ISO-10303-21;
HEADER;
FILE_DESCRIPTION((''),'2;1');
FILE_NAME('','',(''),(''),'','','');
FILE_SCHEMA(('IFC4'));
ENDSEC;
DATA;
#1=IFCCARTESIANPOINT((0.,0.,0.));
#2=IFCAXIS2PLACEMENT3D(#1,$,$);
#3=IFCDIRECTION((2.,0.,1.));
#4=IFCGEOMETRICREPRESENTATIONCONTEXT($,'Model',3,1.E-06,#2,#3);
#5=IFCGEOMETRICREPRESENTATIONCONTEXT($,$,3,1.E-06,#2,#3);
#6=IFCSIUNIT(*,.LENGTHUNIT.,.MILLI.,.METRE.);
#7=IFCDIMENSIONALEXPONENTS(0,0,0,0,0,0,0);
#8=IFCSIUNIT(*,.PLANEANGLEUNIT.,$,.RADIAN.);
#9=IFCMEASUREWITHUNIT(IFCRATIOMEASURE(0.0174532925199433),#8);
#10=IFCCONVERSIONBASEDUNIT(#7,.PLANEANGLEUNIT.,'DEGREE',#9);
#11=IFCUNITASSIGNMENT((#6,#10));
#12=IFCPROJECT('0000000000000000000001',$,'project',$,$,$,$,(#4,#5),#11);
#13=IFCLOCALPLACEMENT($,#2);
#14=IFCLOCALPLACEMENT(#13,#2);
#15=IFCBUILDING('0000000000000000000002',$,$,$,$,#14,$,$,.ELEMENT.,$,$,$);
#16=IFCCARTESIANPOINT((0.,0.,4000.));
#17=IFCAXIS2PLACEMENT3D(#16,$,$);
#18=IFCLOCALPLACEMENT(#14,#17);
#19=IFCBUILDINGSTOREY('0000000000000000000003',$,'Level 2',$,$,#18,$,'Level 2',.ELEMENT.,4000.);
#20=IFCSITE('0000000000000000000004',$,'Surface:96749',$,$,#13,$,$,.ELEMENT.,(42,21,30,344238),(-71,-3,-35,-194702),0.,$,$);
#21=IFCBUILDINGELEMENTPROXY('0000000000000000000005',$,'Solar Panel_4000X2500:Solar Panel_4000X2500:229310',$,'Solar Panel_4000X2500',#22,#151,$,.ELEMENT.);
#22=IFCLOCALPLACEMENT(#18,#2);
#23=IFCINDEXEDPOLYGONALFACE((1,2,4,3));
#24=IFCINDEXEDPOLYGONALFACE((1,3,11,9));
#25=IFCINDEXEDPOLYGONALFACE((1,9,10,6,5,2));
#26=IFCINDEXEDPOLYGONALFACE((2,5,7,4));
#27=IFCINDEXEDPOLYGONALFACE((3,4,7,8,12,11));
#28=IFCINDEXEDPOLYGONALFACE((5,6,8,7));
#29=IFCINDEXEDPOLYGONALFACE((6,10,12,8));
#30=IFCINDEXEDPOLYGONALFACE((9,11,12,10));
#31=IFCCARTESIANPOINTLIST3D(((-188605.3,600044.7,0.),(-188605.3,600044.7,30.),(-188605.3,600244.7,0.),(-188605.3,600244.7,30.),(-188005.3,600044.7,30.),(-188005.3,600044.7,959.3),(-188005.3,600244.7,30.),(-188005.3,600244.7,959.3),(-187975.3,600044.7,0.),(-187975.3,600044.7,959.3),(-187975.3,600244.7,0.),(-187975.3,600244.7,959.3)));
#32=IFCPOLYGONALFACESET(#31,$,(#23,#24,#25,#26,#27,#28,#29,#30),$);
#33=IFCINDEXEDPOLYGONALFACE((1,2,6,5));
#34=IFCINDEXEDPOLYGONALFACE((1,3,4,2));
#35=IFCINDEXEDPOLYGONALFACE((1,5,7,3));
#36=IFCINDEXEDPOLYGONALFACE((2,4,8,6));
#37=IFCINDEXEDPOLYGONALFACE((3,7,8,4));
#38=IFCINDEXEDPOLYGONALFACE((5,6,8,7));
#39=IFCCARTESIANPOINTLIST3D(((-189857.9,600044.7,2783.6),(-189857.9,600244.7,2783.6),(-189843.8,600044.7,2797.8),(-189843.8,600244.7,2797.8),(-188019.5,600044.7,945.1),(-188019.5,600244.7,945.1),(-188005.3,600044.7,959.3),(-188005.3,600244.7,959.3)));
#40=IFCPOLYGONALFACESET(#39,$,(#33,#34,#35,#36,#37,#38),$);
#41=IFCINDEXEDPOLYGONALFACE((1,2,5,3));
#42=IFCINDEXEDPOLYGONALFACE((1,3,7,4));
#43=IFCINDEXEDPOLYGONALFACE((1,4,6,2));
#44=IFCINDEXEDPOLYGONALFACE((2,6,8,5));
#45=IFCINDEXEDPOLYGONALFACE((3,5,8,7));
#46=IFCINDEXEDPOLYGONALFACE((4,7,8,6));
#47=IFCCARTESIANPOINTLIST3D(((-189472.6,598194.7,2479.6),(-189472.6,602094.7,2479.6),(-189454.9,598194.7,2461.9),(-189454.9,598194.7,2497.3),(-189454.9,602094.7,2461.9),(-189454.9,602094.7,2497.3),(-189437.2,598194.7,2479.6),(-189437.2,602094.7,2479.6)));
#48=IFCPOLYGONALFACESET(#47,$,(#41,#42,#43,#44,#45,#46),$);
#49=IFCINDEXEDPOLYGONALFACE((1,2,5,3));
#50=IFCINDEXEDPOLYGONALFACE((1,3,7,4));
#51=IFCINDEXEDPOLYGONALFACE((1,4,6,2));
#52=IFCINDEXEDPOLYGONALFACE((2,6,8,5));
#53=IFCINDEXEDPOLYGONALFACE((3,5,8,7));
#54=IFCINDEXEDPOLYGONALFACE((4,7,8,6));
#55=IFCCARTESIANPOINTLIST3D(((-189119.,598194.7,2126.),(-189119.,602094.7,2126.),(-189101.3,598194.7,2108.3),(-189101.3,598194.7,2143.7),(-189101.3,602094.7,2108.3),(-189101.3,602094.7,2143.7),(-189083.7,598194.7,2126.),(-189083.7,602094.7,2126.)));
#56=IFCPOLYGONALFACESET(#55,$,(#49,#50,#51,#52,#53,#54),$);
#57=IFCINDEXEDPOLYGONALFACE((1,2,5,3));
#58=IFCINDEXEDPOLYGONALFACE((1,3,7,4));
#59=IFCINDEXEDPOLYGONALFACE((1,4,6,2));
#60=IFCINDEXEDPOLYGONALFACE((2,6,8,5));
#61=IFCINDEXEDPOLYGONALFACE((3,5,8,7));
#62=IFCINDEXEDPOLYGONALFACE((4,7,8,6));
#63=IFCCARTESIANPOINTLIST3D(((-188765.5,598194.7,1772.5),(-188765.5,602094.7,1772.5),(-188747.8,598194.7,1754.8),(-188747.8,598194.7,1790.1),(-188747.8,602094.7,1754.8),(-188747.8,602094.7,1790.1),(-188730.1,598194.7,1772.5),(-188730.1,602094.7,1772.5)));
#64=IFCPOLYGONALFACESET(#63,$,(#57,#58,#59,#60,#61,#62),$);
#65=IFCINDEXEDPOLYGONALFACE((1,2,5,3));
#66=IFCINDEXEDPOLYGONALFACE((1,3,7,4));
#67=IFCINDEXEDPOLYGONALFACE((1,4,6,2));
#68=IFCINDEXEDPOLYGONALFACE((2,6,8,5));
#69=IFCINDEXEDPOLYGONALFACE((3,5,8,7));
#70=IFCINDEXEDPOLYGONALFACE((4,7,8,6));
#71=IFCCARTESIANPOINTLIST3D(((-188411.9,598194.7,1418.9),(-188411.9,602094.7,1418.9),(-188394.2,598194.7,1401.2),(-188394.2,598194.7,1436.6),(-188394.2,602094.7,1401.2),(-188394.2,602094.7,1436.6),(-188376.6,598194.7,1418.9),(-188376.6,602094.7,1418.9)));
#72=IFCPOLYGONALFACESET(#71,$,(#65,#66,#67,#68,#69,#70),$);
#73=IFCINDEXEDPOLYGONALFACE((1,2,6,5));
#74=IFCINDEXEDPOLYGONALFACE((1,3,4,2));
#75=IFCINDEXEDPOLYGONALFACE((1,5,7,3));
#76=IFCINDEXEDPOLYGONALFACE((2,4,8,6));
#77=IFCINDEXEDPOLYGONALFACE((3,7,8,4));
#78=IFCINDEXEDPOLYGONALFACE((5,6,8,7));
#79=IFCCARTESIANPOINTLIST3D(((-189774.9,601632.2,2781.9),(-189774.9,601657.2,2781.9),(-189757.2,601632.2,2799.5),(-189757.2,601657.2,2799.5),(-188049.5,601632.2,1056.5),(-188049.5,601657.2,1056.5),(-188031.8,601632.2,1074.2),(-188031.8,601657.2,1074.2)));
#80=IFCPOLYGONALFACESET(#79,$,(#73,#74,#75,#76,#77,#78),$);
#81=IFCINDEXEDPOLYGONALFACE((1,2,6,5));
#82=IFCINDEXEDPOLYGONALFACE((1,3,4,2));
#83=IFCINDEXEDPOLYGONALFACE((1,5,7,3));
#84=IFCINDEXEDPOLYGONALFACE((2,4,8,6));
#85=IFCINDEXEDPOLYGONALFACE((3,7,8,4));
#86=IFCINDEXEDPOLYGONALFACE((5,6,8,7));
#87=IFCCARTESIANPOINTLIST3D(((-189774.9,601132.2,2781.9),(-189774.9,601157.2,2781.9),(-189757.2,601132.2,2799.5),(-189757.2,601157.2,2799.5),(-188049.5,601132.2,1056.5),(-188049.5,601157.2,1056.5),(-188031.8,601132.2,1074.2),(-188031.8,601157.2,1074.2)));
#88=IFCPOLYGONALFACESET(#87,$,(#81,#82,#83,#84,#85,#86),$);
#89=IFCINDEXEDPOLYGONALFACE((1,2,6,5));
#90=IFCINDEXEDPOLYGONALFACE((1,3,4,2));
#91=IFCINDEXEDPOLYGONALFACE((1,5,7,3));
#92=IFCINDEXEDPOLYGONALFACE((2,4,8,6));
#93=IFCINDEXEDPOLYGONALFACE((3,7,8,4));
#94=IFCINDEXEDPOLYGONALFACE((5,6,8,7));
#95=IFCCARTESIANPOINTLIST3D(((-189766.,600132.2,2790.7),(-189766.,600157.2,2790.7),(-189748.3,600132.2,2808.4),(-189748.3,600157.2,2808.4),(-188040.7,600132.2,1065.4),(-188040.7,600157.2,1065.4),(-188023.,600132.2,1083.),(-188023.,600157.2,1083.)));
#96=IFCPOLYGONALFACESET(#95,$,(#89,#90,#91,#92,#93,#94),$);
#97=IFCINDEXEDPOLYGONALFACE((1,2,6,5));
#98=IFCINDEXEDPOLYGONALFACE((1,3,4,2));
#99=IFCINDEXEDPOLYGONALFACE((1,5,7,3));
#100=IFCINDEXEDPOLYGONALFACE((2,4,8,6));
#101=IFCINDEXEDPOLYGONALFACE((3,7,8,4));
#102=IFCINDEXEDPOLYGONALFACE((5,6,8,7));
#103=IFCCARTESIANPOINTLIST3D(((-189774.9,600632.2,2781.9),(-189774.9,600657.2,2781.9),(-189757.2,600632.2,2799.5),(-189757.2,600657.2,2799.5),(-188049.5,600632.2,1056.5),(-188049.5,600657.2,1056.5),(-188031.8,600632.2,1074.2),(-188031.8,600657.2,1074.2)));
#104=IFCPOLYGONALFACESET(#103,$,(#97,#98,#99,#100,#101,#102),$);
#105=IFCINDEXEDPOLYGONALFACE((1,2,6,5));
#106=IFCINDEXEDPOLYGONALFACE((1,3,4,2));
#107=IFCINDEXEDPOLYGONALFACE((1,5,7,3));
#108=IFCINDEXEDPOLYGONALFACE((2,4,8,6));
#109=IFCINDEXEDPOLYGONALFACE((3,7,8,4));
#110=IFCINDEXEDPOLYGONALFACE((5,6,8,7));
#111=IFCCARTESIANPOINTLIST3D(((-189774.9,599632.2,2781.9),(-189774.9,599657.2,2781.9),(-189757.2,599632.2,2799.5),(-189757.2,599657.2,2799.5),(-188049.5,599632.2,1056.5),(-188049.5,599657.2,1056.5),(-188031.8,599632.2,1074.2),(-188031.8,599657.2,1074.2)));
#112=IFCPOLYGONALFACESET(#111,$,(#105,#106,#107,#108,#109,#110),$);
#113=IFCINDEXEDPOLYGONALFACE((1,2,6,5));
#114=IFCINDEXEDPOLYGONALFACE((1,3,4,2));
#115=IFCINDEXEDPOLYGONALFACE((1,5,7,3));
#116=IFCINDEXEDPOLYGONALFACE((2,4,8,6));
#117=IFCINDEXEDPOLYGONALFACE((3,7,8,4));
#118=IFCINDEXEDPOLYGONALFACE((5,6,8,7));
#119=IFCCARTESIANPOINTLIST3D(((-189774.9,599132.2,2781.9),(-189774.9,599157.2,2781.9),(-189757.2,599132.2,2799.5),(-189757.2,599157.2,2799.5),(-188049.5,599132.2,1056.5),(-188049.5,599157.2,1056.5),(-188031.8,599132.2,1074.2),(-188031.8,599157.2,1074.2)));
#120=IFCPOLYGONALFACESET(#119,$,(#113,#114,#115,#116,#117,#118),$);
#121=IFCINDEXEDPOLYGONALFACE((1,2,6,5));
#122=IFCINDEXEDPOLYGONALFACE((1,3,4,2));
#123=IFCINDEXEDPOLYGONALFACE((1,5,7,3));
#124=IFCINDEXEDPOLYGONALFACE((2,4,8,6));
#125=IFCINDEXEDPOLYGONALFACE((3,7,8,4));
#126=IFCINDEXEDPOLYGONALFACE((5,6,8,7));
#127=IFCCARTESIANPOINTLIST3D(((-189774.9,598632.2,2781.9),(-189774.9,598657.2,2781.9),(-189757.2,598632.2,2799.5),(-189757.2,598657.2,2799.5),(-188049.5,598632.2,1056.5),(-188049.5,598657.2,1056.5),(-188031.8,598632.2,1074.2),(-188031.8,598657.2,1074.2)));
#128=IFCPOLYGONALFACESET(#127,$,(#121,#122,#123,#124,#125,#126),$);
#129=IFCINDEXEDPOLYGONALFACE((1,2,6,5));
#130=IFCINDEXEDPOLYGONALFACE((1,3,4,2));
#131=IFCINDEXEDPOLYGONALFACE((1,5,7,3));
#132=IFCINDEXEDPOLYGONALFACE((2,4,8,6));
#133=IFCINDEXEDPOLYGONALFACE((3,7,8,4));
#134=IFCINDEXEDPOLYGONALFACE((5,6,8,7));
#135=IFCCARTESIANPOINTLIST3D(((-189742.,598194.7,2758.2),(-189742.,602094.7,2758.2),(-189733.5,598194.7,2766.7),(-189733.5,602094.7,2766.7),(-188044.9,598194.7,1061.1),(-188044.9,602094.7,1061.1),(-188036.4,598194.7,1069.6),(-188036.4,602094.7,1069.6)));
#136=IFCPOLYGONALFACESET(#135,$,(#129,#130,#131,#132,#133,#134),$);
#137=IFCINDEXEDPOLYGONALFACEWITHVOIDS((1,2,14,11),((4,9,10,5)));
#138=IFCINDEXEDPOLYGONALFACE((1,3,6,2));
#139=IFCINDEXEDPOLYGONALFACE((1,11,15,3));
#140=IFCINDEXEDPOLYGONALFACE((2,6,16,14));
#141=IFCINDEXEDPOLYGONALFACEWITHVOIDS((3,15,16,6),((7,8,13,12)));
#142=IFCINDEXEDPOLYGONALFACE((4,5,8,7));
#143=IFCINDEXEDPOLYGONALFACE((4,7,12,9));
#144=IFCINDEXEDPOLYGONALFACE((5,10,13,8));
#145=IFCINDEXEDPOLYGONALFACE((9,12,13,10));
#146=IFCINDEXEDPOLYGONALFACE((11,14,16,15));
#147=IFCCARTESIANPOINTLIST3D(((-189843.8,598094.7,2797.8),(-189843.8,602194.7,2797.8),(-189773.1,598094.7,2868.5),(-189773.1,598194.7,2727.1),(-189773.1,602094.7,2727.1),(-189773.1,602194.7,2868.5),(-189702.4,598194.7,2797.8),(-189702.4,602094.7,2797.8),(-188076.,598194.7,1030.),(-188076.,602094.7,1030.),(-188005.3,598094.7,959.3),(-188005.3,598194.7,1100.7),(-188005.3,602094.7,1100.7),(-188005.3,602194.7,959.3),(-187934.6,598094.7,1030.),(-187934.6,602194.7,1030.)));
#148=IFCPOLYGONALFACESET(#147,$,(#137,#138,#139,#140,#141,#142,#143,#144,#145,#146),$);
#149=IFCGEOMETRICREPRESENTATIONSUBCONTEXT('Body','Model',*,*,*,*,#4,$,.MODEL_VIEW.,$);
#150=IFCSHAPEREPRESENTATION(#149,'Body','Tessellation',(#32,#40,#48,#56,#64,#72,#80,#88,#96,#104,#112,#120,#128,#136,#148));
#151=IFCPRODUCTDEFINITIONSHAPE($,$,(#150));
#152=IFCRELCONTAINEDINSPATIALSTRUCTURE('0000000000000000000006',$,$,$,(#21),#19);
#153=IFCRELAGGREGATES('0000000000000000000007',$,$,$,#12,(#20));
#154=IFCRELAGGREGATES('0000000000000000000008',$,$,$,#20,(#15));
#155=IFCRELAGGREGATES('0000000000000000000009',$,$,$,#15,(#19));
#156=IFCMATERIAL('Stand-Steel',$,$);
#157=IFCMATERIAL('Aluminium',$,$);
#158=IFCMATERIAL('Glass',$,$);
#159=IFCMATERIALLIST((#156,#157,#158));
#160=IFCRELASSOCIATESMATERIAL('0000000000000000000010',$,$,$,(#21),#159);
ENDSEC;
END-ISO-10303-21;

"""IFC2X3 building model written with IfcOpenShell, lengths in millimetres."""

from ifc_helpers import new_model, entity, si_unit, converted_unit, direction, frame, frame_2d, origin, origin_2d_with_axis, place, context, subcontext, project, spatial, polyline, rectangle, outline, extrude, source, transform, mapped, material, material_list, element, save


model = new_model("IFC2X3")

# Units and contexts
model_context = context("Model", 3, precision=1e-06, world=origin(), true_north=direction((2.0, 0.0, 1.0)))
context_of_model = context(None, 3, precision=1e-06, world=origin(), true_north=direction((2.0, 0.0, 1.0)))
body_context = subcontext(model_context, "Body", "Model", "MODEL_VIEW")
ifc_project = project(units=[si_unit("LENGTHUNIT", "METRE", prefix="MILLI"), converted_unit("PLANEANGLEUNIT", "DEGREE", entity("IfcRatioMeasure", 0.0174532925199433), si_unit("PLANEANGLEUNIT", "RADIAN"), dimensions=[0, 0, 0, 0, 0, 0, 0])], contexts=[model_context, context_of_model])

# Site, building, storey
site_placement = place(None, origin())
site = spatial("IfcSite", under=ifc_project, at=site_placement, Name="Surface:96749", CompositionType="ELEMENT", RefLatitude=(42, 21, 30, 344238), RefLongitude=(-71, -3, -35, -194702), RefElevation=0.0)
building_placement = place(site_placement, origin())
building = spatial("IfcBuilding", under=site, at=building_placement, CompositionType="ELEMENT")
storey_placement = place(building_placement, frame((0.0, 0.0, 4000.0)))
storey = spatial("IfcBuildingStorey", under=building, at=storey_placement, Name="Level 2", LongName="Level 2", CompositionType="ELEMENT", Elevation=4000.0)

# Building element proxy
ifc_material_1 = material(Name="Stand-Steel")
ifc_material_2 = material(Name="Aluminium")
ifc_material_3 = material(Name="Glass")
shared_shape = source(origin(), body_context, "Body", "SweptSolid", [
    extrude(outline(polyline([(-629.5, -220.0), (329.8, -220.0), (329.8, 410.0), (299.8, 410.0), (299.8, -190.0), (-629.5, -190.0), (-629.5, -220.0)])), frame((-190.0, -100.0, 299.8), z_axis=(0.0, 1.0, 0.0), x_axis=(0.0, 0.0, -1.0)), (0.0, 0.0, 1.0), 200.0),
    extrude(rectangle(XDim=20.0, YDim=200.0, at=frame_2d((0.0, 0.0), x_axis=(0.0, 1.0))), frame((-7.1, 0.0, 922.2), z_axis=(-0.707107, 0.0, 0.707107), x_axis=(0.0, 1.0, 0.0)), (0.0, 0.0, 1.0), 2600.0),
    extrude(rectangle(XDim=25.0, YDim=25.0, at=frame_2d((0.0, 0.0), x_axis=(1.0, 0.0))), frame((-1449.6, -1950.0, 2449.6), z_axis=(0.0, 1.0, 0.0), x_axis=(-0.707107, 0.0, -0.707107)), (0.0, 0.0, 1.0), 3900.0),
    extrude(rectangle(XDim=25.0, YDim=25.0, at=origin_2d_with_axis()), frame((-1096.0, -1950.0, 2096.0), z_axis=(0.0, 1.0, 0.0), x_axis=(-0.707107, 0.0, -0.707107)), (0.0, 0.0, 1.0), 3900.0),
    extrude(rectangle(XDim=25.0, YDim=25.0, at=origin_2d_with_axis()), frame((-742.5, -1950.0, 1742.5), z_axis=(0.0, 1.0, 0.0), x_axis=(-0.707107, 0.0, -0.707107)), (0.0, 0.0, 1.0), 3900.0),
    extrude(rectangle(XDim=25.0, YDim=25.0, at=frame_2d((0.0, 0.0), x_axis=(1.0, 0.0))), frame((-388.9, -1950.0, 1388.9), z_axis=(0.0, 1.0, 0.0), x_axis=(-0.707107, 0.0, -0.707107)), (0.0, 0.0, 1.0), 3900.0),
    extrude(rectangle(XDim=25.0, YDim=25.0, at=frame_2d((0.0, 0.0), x_axis=(0.0, 1.0))), frame((-35.4, 1500.0, 1035.4), z_axis=(-0.707107, 0.0, 0.707107), x_axis=(0.0, 1.0, 0.0)), (0.0, 0.0, 1.0), 2440.0),
    extrude(rectangle(XDim=25.0, YDim=25.0, at=frame_2d((0.0, 0.0), x_axis=(0.0, 1.0))), frame((-35.4, 1000.0, 1035.4), z_axis=(-0.707107, 0.0, 0.707107), x_axis=(0.0, 1.0, 0.0)), (0.0, 0.0, 1.0), 2440.0),
    extrude(rectangle(XDim=25.0, YDim=25.0, at=frame_2d((0.0, 0.0), x_axis=(0.0, 1.0))), frame((-26.5, 0.0, 1044.2), z_axis=(-0.707107, 0.0, 0.707107), x_axis=(0.0, -1.0, 0.0)), (0.0, 0.0, 1.0), 2440.0),
    extrude(rectangle(XDim=25.0, YDim=25.0, at=frame_2d((0.0, 0.0), x_axis=(0.0, 1.0))), frame((-35.4, 500.0, 1035.4), z_axis=(-0.707107, 0.0, 0.707107), x_axis=(0.0, 1.0, 0.0)), (0.0, 0.0, 1.0), 2440.0),
    extrude(rectangle(XDim=25.0, YDim=25.0, at=frame_2d((0.0, 0.0), x_axis=(0.0, 1.0))), frame((-35.4, -500.0, 1035.4), z_axis=(-0.707107, 0.0, 0.707107), x_axis=(0.0, 1.0, 0.0)), (0.0, 0.0, 1.0), 2440.0),
    extrude(rectangle(XDim=25.0, YDim=25.0, at=frame_2d((0.0, 0.0), x_axis=(0.0, 1.0))), frame((-35.4, -1000.0, 1035.4), z_axis=(-0.707107, 0.0, 0.707107), x_axis=(0.0, 1.0, 0.0)), (0.0, 0.0, 1.0), 2440.0),
    extrude(rectangle(XDim=25.0, YDim=25.0, at=frame_2d((0.0, 0.0), x_axis=(0.0, 1.0))), frame((-35.4, -1500.0, 1035.4), z_axis=(-0.707107, 0.0, 0.707107), x_axis=(0.0, 1.0, 0.0)), (0.0, 0.0, 1.0), 2440.0),
    extrude(rectangle(XDim=2400.0, YDim=12.0, at=frame_2d((0.0, 0.0), x_axis=(1.0, 0.0))), frame((-883.9, -1950.0, 1883.9), z_axis=(0.0, 1.0, 0.0), x_axis=(0.707107, 0.0, -0.707107)), (0.0, 0.0, 1.0), 3900.0),
    extrude(outline(polyline([(-2050.0, -1300.0), (2050.0, -1300.0), (2050.0, 1300.0), (-2050.0, 1300.0), (-2050.0, -1300.0)]), holes=[polyline([(1950.0, -1200.0), (-1950.0, -1200.0), (-1950.0, 1200.0), (1950.0, 1200.0), (1950.0, -1200.0)])]), frame((-919.2, 0.0, 1848.5), z_axis=(0.707107, 0.0, 0.707107), x_axis=(0.0, 1.0, 0.0)), (0.0, 0.0, 1.0), 100.0),
])
ifc_material_list_1 = material_list([ifc_material_1, ifc_material_2, ifc_material_3])
proxy_1_placement = place(storey_placement, frame((-188005.3, 600144.7, 30.0)))
element("IfcBuildingElementProxy", 1, at=proxy_1_placement, inside=storey, material=ifc_material_list_1, Name="Solar Panel_4000X2500:Solar Panel_4000X2500:229310", ObjectType="Solar Panel_4000X2500", CompositionType="ELEMENT", context=body_context, shape_type="MappedRepresentation", body=[
    mapped(shared_shape, transform((0.0, 0.0, 0.0), scale=1.0)),
])

save(model, "model.ifc")
